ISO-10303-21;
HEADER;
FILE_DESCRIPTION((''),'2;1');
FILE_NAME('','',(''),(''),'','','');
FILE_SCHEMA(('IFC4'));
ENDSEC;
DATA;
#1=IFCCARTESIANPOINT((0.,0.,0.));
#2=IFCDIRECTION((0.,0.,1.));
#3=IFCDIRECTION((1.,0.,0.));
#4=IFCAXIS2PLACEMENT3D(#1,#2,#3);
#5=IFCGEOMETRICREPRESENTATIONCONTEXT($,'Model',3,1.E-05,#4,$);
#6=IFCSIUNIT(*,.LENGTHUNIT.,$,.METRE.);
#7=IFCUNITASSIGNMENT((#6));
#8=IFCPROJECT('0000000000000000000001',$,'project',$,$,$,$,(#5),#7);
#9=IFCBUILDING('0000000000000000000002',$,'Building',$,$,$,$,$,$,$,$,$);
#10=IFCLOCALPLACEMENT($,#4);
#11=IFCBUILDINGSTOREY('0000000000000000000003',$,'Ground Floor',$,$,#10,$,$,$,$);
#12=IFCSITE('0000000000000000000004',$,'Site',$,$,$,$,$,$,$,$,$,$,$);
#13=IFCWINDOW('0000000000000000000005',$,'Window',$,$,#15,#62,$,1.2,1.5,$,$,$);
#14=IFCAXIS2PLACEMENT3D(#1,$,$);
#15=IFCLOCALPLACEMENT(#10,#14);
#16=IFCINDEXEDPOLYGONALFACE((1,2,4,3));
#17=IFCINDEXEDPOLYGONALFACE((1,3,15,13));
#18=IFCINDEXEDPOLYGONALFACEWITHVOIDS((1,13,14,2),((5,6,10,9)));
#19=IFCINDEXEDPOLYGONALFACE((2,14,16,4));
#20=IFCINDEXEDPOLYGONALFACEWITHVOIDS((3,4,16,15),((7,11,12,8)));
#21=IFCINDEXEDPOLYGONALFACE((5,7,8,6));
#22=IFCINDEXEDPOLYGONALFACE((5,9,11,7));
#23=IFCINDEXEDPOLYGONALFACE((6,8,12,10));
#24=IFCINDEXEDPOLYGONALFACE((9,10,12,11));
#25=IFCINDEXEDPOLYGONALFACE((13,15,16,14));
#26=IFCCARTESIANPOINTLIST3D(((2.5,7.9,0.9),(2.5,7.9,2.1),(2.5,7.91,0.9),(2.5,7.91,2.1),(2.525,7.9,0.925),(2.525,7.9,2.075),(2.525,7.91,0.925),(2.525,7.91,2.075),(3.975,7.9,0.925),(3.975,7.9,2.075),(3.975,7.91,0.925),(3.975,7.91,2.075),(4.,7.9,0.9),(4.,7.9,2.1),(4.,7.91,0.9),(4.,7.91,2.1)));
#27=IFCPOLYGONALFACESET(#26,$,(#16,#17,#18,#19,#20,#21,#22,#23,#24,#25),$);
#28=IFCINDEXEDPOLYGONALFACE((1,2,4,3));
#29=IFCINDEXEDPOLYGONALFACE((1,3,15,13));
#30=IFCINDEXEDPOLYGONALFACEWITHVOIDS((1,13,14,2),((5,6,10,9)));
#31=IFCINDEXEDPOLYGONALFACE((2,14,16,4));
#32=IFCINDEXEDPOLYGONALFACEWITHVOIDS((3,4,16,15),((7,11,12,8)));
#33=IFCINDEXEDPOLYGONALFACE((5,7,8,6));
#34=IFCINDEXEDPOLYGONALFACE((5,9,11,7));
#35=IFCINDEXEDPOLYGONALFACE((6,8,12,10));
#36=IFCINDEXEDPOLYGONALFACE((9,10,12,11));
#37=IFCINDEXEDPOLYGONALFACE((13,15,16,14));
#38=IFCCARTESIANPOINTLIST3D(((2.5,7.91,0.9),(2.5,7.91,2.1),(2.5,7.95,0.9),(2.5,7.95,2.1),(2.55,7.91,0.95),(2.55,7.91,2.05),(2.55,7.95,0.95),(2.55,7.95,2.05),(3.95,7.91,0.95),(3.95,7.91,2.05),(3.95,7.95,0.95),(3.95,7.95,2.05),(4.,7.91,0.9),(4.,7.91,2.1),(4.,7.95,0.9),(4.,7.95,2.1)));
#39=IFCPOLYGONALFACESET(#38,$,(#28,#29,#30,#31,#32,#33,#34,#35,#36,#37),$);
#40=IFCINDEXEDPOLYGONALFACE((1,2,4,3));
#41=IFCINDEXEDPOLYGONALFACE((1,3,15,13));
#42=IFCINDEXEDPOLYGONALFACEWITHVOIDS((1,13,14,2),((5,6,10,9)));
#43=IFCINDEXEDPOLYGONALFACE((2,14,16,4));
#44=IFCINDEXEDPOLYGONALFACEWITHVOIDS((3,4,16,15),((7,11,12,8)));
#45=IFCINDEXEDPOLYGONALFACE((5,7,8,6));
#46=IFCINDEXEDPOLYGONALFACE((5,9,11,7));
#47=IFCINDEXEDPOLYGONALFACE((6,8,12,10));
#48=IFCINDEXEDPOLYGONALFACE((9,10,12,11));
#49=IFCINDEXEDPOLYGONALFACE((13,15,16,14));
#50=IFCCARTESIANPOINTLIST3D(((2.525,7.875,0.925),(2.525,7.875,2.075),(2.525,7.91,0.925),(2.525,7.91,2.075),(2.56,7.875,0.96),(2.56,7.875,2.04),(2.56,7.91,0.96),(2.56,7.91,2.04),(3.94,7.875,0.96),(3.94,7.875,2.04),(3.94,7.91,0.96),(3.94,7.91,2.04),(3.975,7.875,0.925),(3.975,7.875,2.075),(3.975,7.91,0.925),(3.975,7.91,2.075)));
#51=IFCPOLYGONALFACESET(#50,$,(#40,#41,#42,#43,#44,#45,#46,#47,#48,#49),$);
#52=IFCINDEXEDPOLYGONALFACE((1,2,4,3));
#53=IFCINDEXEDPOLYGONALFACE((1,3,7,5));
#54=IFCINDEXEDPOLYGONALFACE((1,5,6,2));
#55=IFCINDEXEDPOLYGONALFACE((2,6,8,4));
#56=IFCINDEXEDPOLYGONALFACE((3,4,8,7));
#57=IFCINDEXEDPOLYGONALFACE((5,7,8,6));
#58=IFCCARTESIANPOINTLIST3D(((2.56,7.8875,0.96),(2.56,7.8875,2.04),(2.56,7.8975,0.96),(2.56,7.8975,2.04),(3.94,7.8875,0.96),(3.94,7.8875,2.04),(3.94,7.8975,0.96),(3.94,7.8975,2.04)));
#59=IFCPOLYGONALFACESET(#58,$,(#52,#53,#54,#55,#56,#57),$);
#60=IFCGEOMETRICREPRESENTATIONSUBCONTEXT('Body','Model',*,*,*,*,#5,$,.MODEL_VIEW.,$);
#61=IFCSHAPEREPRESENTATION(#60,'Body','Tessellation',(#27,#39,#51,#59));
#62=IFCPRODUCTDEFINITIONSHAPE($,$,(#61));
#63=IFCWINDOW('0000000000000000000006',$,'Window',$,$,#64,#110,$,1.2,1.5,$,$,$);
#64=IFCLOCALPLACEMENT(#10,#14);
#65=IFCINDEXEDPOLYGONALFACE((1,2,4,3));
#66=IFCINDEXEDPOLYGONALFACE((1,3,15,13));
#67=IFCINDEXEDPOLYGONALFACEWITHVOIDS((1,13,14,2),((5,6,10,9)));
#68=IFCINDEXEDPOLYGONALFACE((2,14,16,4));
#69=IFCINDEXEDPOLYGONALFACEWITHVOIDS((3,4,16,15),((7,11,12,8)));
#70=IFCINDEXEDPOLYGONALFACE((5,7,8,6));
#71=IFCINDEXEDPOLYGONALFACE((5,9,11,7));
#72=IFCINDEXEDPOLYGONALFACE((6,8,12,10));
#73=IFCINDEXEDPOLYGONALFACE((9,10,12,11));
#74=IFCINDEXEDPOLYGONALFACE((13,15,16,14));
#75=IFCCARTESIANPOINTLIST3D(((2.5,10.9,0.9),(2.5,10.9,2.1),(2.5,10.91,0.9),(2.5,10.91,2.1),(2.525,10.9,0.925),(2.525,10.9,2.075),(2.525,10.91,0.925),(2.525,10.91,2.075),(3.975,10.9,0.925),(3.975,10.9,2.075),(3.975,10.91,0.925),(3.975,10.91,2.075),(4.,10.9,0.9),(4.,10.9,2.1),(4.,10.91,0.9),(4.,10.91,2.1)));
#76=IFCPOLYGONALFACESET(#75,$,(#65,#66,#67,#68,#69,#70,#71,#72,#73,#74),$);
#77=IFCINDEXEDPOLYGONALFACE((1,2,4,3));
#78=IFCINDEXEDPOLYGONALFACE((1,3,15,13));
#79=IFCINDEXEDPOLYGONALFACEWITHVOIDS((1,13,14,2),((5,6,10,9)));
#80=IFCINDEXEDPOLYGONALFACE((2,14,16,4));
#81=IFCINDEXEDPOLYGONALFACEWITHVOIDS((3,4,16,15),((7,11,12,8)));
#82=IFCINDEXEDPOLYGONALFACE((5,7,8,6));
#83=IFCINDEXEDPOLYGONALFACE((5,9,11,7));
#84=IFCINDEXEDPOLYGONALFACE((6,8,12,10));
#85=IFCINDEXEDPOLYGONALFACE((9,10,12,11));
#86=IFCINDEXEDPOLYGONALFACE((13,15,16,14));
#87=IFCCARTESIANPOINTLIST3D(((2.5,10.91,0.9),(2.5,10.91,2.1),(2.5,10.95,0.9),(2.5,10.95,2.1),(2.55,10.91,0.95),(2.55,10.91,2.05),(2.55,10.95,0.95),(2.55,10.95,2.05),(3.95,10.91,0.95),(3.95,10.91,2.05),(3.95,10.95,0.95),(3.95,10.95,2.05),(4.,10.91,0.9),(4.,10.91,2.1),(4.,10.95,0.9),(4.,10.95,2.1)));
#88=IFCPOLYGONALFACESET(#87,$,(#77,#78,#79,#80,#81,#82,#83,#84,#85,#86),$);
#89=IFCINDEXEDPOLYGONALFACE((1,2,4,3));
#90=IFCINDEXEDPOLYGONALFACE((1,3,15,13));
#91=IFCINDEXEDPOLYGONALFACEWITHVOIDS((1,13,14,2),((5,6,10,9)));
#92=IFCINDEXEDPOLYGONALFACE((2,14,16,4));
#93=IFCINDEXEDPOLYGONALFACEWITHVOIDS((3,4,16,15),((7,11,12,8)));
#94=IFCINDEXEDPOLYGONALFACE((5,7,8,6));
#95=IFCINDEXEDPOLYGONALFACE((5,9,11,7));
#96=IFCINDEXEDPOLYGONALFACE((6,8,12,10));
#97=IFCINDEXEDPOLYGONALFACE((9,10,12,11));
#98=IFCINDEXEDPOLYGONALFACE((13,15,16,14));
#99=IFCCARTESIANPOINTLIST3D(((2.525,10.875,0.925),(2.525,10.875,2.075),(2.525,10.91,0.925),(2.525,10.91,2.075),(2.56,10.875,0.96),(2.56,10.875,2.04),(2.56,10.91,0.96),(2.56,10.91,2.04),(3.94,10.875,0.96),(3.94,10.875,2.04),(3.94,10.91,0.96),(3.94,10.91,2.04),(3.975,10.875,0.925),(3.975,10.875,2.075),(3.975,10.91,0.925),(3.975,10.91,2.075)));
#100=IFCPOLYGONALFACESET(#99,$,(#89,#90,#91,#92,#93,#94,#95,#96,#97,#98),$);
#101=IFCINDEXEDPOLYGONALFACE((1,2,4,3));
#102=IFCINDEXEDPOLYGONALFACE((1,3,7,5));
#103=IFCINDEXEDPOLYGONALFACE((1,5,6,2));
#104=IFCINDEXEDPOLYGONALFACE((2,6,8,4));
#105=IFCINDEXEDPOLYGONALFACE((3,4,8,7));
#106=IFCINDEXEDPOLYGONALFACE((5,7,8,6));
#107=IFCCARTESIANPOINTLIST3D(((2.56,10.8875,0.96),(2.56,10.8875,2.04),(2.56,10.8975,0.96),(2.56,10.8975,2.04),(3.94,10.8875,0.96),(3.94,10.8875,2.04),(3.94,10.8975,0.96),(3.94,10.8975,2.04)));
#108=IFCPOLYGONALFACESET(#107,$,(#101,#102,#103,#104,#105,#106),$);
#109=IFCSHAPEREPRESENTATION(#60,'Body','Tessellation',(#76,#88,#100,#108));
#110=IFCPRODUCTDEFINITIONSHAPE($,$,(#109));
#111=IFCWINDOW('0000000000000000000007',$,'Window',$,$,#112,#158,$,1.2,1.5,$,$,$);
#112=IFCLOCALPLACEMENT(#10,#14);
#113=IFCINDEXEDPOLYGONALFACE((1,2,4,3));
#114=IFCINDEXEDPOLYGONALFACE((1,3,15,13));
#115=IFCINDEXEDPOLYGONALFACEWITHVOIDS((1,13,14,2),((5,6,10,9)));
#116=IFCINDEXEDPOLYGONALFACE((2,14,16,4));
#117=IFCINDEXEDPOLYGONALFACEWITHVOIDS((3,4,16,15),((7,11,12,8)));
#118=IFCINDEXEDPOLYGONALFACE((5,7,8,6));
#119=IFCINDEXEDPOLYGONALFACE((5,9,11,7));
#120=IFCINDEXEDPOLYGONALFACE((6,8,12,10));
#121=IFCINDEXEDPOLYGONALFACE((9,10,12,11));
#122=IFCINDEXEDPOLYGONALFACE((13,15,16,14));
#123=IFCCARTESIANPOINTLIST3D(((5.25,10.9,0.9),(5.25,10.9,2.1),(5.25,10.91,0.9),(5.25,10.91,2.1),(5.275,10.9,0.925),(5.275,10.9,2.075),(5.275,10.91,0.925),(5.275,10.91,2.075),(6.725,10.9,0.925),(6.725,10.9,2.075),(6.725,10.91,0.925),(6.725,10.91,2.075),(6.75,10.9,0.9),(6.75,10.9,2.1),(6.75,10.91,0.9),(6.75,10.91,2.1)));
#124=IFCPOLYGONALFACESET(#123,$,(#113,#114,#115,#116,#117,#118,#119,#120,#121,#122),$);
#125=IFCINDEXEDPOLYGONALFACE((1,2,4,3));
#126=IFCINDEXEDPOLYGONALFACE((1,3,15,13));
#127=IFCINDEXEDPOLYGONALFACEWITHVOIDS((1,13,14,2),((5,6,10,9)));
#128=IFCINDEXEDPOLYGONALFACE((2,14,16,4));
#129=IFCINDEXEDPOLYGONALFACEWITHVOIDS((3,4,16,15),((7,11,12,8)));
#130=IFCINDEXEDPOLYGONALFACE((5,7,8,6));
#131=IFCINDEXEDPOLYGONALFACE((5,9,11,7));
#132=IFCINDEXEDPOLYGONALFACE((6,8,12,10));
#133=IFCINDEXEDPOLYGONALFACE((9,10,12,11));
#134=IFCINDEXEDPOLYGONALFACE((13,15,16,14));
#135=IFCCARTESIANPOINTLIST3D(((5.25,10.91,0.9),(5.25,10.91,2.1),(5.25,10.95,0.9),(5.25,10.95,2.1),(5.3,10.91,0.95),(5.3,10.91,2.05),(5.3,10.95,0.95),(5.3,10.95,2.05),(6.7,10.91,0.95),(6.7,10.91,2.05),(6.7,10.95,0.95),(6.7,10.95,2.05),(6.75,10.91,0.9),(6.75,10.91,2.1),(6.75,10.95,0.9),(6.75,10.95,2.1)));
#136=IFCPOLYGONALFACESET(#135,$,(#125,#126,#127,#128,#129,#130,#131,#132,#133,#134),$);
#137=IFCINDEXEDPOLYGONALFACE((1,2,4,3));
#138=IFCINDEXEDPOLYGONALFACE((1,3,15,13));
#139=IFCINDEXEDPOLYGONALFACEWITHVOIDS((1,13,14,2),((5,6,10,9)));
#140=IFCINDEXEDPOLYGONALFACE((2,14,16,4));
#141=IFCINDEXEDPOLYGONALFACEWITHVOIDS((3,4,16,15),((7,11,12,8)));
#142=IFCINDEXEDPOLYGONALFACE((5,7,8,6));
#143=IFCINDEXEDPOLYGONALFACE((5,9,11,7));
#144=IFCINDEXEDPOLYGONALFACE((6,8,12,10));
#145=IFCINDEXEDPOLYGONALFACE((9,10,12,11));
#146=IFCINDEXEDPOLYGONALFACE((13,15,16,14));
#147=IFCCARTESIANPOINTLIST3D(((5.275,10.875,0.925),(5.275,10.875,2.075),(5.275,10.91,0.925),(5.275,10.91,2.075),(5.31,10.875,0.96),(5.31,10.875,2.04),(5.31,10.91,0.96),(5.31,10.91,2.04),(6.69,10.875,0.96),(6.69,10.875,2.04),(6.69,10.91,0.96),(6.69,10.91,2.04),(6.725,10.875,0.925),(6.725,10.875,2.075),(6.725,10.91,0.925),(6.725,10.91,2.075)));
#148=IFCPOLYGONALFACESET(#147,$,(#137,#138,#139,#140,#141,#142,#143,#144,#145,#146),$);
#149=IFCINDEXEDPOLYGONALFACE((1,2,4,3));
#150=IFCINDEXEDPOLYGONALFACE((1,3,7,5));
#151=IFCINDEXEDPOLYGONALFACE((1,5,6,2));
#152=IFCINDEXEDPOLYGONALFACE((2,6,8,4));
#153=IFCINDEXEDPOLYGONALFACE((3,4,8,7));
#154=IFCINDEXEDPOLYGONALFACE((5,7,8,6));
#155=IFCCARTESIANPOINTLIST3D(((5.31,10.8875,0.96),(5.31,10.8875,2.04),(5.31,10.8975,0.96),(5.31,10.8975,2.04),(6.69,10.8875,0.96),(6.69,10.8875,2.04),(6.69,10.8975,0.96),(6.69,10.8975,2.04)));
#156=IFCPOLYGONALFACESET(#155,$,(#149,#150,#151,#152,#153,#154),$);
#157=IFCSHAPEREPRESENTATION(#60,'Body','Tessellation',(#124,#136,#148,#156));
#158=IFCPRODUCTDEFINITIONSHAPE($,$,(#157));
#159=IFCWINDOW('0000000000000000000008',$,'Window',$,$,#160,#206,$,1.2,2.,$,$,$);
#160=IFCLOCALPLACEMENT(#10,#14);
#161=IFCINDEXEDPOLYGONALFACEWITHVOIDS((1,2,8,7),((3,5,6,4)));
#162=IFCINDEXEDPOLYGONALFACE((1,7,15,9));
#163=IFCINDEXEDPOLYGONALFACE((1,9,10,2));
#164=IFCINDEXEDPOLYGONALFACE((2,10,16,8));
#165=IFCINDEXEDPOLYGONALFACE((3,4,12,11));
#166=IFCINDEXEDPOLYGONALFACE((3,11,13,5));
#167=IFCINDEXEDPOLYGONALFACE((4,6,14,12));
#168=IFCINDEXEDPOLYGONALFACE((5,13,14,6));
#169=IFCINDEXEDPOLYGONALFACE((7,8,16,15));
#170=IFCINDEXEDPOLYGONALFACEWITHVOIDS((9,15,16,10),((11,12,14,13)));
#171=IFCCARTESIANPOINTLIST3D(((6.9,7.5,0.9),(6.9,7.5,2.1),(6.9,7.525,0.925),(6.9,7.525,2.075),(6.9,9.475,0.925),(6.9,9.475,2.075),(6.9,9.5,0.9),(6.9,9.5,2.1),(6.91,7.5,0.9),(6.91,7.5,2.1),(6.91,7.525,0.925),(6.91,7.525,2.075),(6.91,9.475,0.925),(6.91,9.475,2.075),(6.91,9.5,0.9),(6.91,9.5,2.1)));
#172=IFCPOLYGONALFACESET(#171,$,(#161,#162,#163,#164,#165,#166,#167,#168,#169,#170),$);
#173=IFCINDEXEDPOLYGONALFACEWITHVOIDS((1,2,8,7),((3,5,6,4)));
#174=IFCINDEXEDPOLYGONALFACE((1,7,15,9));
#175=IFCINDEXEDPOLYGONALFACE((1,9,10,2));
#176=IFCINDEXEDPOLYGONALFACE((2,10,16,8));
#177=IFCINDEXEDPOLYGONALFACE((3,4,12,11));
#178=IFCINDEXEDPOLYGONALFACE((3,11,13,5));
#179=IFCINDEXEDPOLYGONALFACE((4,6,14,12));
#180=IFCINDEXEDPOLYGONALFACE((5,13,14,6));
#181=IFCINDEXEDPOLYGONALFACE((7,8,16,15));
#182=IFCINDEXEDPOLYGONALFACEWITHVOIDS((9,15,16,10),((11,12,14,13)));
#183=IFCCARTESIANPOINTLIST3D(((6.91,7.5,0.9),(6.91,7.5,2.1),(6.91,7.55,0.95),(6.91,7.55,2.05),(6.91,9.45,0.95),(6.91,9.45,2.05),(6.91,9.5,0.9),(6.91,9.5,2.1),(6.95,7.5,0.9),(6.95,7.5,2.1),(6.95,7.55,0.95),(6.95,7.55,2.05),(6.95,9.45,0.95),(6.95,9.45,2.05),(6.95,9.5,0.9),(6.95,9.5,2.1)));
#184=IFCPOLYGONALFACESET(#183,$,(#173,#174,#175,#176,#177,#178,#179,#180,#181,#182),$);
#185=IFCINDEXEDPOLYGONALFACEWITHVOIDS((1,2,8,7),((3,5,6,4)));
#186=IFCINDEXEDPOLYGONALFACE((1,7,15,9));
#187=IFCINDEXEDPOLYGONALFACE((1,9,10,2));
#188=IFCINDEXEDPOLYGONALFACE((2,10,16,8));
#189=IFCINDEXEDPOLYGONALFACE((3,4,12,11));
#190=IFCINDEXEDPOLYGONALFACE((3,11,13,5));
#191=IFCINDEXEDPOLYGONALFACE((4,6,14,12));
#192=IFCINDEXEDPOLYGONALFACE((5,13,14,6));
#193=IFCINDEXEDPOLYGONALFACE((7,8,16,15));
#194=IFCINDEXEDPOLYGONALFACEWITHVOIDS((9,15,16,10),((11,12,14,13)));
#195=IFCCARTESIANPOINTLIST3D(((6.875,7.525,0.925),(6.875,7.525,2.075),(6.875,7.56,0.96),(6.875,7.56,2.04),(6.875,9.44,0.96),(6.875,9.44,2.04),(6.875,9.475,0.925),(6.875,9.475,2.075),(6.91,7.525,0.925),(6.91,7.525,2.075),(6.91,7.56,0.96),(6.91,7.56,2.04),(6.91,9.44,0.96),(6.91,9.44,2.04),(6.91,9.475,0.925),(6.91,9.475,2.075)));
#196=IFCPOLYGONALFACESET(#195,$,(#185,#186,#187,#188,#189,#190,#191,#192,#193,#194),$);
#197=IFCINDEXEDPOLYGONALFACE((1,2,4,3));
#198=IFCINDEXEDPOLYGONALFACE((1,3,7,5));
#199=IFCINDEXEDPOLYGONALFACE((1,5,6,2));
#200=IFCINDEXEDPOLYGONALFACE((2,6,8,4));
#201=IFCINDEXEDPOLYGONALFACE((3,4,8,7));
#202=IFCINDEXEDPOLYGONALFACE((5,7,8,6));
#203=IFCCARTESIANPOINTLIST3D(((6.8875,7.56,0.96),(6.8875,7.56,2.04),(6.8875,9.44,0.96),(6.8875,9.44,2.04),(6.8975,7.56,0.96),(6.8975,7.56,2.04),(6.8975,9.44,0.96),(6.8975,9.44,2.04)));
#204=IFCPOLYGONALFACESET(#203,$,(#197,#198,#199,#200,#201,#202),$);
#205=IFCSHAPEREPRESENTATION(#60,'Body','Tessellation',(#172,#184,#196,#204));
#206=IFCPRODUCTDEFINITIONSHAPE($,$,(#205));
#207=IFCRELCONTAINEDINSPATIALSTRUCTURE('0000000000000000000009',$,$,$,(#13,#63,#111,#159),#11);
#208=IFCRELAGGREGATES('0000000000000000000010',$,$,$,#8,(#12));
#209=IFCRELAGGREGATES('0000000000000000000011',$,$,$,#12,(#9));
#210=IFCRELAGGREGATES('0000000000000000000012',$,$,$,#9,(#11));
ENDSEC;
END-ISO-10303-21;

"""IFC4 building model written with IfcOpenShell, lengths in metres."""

from ifc_helpers import new_model, si_unit, frame, origin_with_axes, place, context, subcontext, project, spatial, line, indexed_curve, outline, extrude, element, save


model = new_model("IFC4")

# Units and contexts
model_context = context("Model", 3, precision=1e-05, world=origin_with_axes())
body_context = subcontext(model_context, "Body", "Model", "MODEL_VIEW")
ifc_project = project(units=[si_unit("LENGTHUNIT", "METRE")], contexts=[model_context])

# Site, building, storey
site = spatial("IfcSite", under=ifc_project, Name="Site")
building = spatial("IfcBuilding", under=site, Name="Building")
storey_placement = place(None, origin_with_axes())
storey = spatial("IfcBuildingStorey", under=building, at=storey_placement, Name="Ground Floor")

# Windows
for number, where, z_axis, x_axis, name in (
    (1, (4.0, 8.0, 0.9), (0.0, 0.0, 1.0), (-1.0, 0.0, 0.0), "Window"),
    (2, (4.0, 11.0, 0.9), (0.0, 0.0, 1.0), (-1.0, 0.0, 0.0), "Window"),
    (3, (6.75, 11.0, 0.9), (0.0, 0.0, 1.0), (-1.0, 0.0, 0.0), "Window"),
):
    element("IfcWindow", number, at=place(storey_placement, frame(where, z_axis=z_axis, x_axis=x_axis)), inside=storey, Name=name, OverallHeight=1.2, OverallWidth=1.5, context=body_context, shape_type="SweptSolid", body=[
        extrude(outline(indexed_curve([(0.0, 0.0), (1.5, 0.0), (1.5, 1.2), (0.0, 1.2)], segments=[line(1, 2, 3, 4, 1)]), holes=[indexed_curve([(0.025, 0.025), (1.475, 0.025), (1.475, 1.175), (0.025, 1.175)], segments=[line(1, 2, 3, 4, 1)])]), frame((0.0, 0.09, 0.0), z_axis=(0.0, -1.0, 0.0), x_axis=(1.0, 0.0, 0.0)), (0.0, 0.0, -1.0), 0.01),
        extrude(outline(indexed_curve([(0.0, 0.0), (1.5, 0.0), (1.5, 1.2), (0.0, 1.2)], segments=[line(1, 2, 3, 4, 1)]), holes=[indexed_curve([(0.05, 0.05), (1.45, 0.05), (1.45, 1.15), (0.05, 1.15)], segments=[line(1, 2, 3, 4, 1)])]), frame((0.0, 0.05, 0.0), z_axis=(0.0, -1.0, 0.0), x_axis=(1.0, 0.0, 0.0)), (0.0, 0.0, -1.0), 0.04),
        extrude(outline(indexed_curve([(0.0, 0.0), (1.45, 0.0), (1.45, 1.15), (0.0, 1.15)], segments=[line(1, 2, 3, 4, 1)]), holes=[indexed_curve([(0.035, 0.035), (1.415, 0.035), (1.415, 1.115), (0.035, 1.115)], segments=[line(1, 2, 3, 4, 1)])]), frame((0.025, 0.09, 0.025), z_axis=(0.0, -1.0, 0.0), x_axis=(1.0, 0.0, 0.0)), (0.0, 0.0, -1.0), 0.035),
        extrude(outline(indexed_curve([(0.035, 0.035), (1.415, 0.035), (1.415, 1.115), (0.035, 1.115)], segments=[line(1, 2, 3, 4, 1)])), frame((0.025, 0.1025, 0.025), z_axis=(0.0, -1.0, 0.0), x_axis=(1.0, 0.0, 0.0)), (0.0, 0.0, -1.0), 0.01),
    ])
window_1_placement = place(storey_placement, frame((7.0, 7.5, 0.9), z_axis=(0.0, 0.0, 1.0), x_axis=(0.0, 1.0, 0.0)))
element("IfcWindow", 4, at=window_1_placement, inside=storey, Name="Window", OverallHeight=1.2, OverallWidth=2.0, context=body_context, shape_type="SweptSolid", body=[
    extrude(outline(indexed_curve([(0.0, 0.0), (2.0, 0.0), (2.0, 1.2), (0.0, 1.2)], segments=[line(1, 2, 3, 4, 1)]), holes=[indexed_curve([(0.025, 0.025), (1.975, 0.025), (1.975, 1.175), (0.025, 1.175)], segments=[line(1, 2, 3, 4, 1)])]), frame((0.0, 0.09, 0.0), z_axis=(0.0, -1.0, 0.0), x_axis=(1.0, 0.0, 0.0)), (0.0, 0.0, -1.0), 0.01),
    extrude(outline(indexed_curve([(0.0, 0.0), (2.0, 0.0), (2.0, 1.2), (0.0, 1.2)], segments=[line(1, 2, 3, 4, 1)]), holes=[indexed_curve([(0.05, 0.05), (1.95, 0.05), (1.95, 1.15), (0.05, 1.15)], segments=[line(1, 2, 3, 4, 1)])]), frame((0.0, 0.05, 0.0), z_axis=(0.0, -1.0, 0.0), x_axis=(1.0, 0.0, 0.0)), (0.0, 0.0, -1.0), 0.04),
    extrude(outline(indexed_curve([(0.0, 0.0), (1.95, 0.0), (1.95, 1.15), (0.0, 1.15)], segments=[line(1, 2, 3, 4, 1)]), holes=[indexed_curve([(0.035, 0.035), (1.915, 0.035), (1.915, 1.115), (0.035, 1.115)], segments=[line(1, 2, 3, 4, 1)])]), frame((0.025, 0.09, 0.025), z_axis=(0.0, -1.0, 0.0), x_axis=(1.0, 0.0, 0.0)), (0.0, 0.0, -1.0), 0.035),
    extrude(outline(indexed_curve([(0.035, 0.035), (1.915, 0.035), (1.915, 1.115), (0.035, 1.115)], segments=[line(1, 2, 3, 4, 1)])), frame((0.025, 0.1025, 0.025), z_axis=(0.0, -1.0, 0.0), x_axis=(1.0, 0.0, 0.0)), (0.0, 0.0, -1.0), 0.01),
])

save(model, "model.ifc")
